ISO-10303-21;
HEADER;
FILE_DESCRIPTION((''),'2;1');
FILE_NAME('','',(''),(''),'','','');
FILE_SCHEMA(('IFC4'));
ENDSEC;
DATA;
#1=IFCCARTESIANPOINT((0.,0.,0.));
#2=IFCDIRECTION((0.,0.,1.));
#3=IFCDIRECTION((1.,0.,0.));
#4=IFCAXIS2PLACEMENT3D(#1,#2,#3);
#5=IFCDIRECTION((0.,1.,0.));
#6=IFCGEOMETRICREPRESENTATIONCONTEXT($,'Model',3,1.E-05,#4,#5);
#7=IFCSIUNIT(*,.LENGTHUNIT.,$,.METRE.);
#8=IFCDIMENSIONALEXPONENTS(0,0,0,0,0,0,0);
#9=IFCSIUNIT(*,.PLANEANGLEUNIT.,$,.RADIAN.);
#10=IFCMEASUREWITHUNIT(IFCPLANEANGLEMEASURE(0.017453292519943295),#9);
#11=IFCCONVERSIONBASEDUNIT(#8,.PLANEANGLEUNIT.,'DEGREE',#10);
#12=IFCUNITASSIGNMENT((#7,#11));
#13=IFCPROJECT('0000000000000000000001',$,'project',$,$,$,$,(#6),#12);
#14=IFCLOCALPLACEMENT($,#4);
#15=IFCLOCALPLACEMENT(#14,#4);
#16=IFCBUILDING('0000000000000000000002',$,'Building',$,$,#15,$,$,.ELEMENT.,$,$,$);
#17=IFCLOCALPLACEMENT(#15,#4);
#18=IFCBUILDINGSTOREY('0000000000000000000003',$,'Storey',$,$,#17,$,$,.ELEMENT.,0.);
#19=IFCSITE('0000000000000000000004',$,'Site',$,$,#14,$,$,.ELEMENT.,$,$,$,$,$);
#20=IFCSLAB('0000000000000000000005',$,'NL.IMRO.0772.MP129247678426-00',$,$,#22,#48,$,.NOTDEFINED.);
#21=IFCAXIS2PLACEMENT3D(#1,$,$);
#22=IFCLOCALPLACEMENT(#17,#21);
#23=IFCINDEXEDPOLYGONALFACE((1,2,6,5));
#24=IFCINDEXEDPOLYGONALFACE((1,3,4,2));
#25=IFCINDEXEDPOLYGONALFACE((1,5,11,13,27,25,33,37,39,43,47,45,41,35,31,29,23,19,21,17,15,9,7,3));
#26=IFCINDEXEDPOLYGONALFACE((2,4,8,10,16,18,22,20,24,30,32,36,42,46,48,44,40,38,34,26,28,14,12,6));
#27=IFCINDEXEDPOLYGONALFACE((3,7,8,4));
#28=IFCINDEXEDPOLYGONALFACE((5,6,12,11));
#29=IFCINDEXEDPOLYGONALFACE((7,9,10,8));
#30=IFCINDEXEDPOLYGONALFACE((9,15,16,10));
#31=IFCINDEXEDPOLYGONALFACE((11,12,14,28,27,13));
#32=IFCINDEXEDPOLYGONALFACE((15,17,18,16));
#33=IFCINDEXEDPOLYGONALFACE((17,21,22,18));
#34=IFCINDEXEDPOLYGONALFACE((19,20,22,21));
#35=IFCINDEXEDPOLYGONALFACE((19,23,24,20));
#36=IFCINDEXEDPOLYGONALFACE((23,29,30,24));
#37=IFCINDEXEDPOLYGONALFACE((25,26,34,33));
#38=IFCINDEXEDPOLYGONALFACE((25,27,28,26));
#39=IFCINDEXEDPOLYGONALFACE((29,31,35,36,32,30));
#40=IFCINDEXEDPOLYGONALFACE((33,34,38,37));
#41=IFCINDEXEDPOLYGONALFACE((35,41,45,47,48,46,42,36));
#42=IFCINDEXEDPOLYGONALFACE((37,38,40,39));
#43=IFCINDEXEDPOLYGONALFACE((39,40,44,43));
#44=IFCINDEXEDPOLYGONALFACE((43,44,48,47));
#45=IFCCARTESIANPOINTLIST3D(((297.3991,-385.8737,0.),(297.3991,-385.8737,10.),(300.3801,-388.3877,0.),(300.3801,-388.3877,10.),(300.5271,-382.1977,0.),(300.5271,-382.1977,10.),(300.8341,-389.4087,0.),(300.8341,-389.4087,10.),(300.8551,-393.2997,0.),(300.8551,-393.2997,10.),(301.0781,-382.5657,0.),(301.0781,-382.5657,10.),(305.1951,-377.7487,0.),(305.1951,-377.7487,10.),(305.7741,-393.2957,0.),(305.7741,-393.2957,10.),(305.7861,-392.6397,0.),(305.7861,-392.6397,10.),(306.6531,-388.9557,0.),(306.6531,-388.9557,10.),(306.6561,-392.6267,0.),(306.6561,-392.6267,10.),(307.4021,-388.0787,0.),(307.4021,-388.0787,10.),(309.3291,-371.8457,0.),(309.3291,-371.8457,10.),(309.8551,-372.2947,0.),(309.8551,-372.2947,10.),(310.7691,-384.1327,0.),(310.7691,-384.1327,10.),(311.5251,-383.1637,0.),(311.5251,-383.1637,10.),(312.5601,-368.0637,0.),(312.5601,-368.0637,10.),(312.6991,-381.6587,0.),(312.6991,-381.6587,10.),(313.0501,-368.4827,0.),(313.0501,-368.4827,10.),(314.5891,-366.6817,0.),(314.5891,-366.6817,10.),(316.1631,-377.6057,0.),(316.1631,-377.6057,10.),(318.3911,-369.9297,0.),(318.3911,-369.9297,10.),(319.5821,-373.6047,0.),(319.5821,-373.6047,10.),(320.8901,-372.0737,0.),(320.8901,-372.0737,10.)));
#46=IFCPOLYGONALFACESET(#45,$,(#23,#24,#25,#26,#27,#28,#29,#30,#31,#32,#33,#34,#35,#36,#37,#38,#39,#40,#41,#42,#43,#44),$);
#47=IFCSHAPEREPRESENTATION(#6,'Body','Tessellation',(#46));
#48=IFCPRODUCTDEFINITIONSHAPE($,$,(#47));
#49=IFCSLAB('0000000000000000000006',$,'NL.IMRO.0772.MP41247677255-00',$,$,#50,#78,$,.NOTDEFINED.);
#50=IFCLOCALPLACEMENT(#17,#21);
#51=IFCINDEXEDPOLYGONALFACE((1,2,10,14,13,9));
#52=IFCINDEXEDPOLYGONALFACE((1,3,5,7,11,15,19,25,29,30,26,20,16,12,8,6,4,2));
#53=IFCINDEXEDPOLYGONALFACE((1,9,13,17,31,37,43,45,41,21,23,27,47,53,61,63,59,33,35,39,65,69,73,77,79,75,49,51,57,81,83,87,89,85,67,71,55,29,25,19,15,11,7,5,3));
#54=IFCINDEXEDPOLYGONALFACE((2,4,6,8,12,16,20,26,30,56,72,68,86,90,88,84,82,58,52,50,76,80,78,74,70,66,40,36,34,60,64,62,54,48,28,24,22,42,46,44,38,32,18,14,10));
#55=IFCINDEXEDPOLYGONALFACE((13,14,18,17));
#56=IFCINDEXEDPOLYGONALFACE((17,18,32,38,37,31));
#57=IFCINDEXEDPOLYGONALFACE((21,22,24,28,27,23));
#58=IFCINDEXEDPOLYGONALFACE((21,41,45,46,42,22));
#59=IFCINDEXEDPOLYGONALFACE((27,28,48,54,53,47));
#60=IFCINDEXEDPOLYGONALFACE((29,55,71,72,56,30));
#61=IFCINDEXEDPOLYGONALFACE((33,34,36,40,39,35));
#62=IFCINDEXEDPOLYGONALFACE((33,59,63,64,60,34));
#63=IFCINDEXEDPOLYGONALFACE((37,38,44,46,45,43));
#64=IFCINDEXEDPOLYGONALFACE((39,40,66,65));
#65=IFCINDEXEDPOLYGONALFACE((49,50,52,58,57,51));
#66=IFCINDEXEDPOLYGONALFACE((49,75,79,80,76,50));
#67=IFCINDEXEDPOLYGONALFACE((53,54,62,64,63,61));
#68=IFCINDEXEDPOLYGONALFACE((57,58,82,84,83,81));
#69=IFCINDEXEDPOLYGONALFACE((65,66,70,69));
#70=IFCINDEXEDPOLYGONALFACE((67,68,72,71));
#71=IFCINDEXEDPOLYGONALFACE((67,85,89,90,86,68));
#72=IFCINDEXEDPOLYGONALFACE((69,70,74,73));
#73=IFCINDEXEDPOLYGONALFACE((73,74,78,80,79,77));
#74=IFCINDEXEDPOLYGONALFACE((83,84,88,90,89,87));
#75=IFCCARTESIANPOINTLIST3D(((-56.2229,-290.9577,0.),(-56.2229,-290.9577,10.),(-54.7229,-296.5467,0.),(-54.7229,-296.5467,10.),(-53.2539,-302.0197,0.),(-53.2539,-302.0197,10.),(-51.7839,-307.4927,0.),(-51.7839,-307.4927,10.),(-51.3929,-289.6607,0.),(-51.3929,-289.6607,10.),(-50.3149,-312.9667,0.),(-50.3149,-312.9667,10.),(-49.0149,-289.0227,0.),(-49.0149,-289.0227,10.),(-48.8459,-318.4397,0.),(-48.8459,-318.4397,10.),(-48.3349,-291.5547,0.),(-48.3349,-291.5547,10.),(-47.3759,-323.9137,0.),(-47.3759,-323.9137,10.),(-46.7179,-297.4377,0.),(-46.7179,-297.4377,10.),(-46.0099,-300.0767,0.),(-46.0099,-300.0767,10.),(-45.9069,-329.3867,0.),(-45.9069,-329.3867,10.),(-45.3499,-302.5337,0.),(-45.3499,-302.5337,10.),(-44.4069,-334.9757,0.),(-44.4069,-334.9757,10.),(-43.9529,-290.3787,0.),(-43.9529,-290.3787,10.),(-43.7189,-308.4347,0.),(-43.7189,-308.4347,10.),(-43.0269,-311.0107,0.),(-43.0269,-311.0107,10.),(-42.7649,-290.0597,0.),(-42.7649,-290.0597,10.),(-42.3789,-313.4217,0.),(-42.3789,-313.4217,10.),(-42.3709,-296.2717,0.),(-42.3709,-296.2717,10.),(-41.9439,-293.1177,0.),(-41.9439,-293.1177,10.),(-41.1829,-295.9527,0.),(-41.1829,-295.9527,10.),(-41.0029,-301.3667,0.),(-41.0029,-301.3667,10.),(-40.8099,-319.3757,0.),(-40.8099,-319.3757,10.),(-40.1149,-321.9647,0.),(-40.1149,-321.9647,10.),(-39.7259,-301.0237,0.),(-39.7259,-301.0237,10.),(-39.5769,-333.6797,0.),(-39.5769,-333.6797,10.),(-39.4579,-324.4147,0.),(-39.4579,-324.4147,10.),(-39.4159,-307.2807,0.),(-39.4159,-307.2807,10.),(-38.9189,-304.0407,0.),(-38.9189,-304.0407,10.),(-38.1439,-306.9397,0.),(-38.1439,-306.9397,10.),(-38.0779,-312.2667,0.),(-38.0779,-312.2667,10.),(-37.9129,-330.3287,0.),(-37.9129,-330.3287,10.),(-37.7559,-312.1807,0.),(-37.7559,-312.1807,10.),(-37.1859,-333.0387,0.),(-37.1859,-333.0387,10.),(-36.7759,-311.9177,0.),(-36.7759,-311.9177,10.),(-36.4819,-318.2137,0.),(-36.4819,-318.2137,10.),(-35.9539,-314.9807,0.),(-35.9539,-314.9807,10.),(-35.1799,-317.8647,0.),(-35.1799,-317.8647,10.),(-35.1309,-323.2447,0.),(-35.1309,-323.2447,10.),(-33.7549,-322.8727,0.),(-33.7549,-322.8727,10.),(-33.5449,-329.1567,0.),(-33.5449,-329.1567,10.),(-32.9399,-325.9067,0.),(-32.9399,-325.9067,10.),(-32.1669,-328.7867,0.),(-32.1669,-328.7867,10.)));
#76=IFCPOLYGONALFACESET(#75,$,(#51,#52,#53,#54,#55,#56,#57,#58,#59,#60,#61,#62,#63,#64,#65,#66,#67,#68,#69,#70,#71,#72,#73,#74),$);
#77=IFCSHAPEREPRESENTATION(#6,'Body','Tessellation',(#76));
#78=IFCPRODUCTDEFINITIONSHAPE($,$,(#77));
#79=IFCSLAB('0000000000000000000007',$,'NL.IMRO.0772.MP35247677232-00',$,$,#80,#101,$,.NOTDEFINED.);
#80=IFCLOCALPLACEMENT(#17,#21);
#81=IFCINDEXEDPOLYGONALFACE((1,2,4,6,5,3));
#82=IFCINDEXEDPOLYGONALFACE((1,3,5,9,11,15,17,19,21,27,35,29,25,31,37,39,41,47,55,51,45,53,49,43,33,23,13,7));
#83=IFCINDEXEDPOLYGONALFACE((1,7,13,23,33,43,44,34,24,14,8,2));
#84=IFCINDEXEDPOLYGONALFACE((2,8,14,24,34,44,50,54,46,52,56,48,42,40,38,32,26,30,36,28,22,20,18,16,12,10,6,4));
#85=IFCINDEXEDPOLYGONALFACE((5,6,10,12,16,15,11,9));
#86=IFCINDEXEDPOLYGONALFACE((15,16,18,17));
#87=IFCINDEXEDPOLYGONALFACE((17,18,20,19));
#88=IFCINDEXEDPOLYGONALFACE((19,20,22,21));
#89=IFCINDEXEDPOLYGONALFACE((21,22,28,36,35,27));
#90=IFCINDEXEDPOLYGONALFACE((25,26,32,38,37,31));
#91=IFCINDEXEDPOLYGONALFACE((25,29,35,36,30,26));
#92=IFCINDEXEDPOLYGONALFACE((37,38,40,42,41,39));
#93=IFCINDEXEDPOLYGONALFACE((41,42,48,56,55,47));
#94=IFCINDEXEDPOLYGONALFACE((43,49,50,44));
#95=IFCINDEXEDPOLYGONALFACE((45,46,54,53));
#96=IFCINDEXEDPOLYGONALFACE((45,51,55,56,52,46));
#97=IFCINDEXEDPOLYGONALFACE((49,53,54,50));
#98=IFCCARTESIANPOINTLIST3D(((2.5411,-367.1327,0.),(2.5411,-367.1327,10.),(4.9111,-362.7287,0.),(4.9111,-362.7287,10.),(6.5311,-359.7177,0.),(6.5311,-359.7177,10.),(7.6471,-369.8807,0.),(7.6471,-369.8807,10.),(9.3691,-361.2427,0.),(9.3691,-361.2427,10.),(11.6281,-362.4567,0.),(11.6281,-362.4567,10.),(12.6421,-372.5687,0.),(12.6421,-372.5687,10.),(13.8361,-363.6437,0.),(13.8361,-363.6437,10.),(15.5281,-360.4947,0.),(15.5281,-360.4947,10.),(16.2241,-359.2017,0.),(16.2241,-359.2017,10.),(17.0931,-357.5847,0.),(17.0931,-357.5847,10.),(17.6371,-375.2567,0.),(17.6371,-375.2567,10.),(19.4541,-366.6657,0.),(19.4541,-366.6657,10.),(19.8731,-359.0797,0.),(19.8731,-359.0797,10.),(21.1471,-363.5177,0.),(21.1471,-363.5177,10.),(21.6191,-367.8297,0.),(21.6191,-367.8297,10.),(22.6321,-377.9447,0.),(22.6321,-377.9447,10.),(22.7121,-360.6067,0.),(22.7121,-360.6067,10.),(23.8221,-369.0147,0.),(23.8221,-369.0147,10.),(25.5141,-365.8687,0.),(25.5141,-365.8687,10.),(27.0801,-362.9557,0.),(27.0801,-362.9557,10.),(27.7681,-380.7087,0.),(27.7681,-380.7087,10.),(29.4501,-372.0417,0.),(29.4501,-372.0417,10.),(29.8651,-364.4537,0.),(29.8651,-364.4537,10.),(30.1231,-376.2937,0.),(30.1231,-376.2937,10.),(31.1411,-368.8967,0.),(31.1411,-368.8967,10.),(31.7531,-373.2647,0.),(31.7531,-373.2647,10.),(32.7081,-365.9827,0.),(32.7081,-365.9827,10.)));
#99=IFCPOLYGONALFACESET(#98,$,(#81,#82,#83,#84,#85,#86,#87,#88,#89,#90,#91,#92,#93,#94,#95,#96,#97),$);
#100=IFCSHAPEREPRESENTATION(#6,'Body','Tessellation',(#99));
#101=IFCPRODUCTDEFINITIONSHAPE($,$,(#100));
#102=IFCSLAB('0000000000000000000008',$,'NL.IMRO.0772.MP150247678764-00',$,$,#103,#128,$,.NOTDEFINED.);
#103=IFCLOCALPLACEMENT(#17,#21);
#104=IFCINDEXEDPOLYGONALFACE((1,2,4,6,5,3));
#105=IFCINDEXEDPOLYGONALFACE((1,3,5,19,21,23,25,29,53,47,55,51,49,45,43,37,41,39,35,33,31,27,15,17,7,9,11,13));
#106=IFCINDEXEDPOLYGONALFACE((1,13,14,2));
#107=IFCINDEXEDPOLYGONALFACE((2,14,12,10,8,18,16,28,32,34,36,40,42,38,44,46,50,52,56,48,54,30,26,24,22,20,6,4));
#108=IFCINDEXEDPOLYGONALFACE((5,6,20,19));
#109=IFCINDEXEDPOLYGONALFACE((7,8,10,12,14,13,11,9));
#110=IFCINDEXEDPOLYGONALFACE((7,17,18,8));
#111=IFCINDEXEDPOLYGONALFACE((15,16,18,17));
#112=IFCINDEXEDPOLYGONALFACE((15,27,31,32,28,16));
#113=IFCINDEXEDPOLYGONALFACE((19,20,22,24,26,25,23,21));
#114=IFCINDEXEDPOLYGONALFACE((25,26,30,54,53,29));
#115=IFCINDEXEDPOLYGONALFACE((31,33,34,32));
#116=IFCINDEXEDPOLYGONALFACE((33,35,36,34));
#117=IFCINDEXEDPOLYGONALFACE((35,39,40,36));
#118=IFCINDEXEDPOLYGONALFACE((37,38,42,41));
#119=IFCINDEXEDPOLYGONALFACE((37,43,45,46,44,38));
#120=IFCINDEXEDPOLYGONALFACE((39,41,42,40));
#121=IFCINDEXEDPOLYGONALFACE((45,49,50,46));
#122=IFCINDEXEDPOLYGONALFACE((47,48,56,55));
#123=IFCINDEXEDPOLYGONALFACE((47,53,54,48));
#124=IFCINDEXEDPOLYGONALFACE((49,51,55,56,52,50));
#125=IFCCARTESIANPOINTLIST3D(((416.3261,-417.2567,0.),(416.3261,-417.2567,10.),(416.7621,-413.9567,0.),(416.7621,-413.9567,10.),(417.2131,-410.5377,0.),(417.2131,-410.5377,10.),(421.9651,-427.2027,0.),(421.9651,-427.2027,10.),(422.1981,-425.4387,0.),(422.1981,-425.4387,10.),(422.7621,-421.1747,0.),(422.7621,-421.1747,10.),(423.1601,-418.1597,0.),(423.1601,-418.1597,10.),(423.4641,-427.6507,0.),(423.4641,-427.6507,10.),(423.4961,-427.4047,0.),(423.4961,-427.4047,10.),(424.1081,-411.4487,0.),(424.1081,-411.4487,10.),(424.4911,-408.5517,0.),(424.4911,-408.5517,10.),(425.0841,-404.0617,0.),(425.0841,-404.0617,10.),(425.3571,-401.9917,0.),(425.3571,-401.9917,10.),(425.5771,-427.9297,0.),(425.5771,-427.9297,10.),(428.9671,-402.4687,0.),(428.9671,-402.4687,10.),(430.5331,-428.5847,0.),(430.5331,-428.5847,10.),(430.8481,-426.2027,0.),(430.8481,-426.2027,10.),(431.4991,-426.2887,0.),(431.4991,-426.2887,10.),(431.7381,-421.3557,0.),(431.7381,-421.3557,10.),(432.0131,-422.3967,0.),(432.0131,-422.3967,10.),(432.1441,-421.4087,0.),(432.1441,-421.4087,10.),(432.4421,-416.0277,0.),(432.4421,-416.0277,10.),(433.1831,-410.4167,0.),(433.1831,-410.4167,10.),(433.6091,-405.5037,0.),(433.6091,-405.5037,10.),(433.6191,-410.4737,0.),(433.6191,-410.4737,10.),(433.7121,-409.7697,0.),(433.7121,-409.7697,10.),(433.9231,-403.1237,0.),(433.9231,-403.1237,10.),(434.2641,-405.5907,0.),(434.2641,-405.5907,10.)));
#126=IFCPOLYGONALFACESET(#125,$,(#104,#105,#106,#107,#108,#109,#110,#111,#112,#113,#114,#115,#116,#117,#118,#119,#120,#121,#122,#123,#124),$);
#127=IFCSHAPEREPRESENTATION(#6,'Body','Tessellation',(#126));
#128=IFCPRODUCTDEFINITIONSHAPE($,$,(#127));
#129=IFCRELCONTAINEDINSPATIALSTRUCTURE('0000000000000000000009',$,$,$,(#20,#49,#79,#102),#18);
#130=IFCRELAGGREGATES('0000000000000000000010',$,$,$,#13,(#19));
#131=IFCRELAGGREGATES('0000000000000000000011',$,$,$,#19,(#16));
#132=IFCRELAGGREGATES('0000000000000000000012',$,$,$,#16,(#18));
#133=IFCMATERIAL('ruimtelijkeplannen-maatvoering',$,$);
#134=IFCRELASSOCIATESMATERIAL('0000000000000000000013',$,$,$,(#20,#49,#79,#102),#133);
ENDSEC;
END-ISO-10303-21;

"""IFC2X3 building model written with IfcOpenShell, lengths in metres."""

from ifc_helpers import new_model, entity, si_unit, converted_unit, direction, origin_with_axes, place, context, project, spatial, polyline, outline, extrude, material, element, save


model = new_model("IFC2X3")

# Units and contexts
model_context = context("Model", 3, precision=1e-05, world=origin_with_axes(), true_north=direction((0.0, 1.0, 0.0)))
ifc_project = project(units=[si_unit("LENGTHUNIT", "METRE"), converted_unit("PLANEANGLEUNIT", "DEGREE", entity("IfcPlaneAngleMeasure", 0.017453292519943295), si_unit("PLANEANGLEUNIT", "RADIAN"), dimensions=[0, 0, 0, 0, 0, 0, 0])], contexts=[model_context])

# Site, building, storey
site_placement = place(None, origin_with_axes())
site = spatial("IfcSite", under=ifc_project, at=site_placement, Name="Site", CompositionType="ELEMENT")
building_placement = place(site_placement, origin_with_axes())
building = spatial("IfcBuilding", under=site, at=building_placement, Name="Building", CompositionType="ELEMENT")
storey_placement = place(building_placement, origin_with_axes())
storey = spatial("IfcBuildingStorey", under=building, at=storey_placement, Name="Storey", CompositionType="ELEMENT", Elevation=0.0)

# Slabs
ifc_material = material(Name="ruimtelijkeplannen-maatvoering")
slab_1_placement = place(storey_placement, origin_with_axes())
element("IfcSlab", 1, at=slab_1_placement, inside=storey, material=ifc_material, Name="NL.IMRO.0772.MP129247678426-00", PredefinedType="NOTDEFINED", context=model_context, shape_type="SweptSolid", body=[
    extrude(outline(polyline([(300.3801, -388.3877), (297.3991, -385.8737), (300.5271, -382.1977), (301.0781, -382.5657), (305.1951, -377.7487), (309.8551, -372.2947), (309.3291, -371.8457), (312.5601, -368.0637), (313.0501, -368.4827), (314.5891, -366.6817), (318.3911, -369.9297), (320.8901, -372.0737), (319.5821, -373.6047), (316.1631, -377.6057), (312.6991, -381.6587), (311.5251, -383.1637), (310.7691, -384.1327), (307.4021, -388.0787), (306.6531, -388.9557), (306.6561, -392.6267), (305.7861, -392.6397), (305.7741, -393.2957), (300.8551, -393.2997), (300.8341, -389.4087), (300.3801, -388.3877)])), origin_with_axes(), (0.0, 0.0, 1.0), 10.0),
])
slab_2_placement = place(storey_placement, origin_with_axes())
element("IfcSlab", 2, at=slab_2_placement, inside=storey, material=ifc_material, Name="NL.IMRO.0772.MP41247677255-00", PredefinedType="NOTDEFINED", context=model_context, shape_type="SweptSolid", body=[
    extrude(outline(polyline([(-56.2229, -290.9577), (-51.3929, -289.6607), (-49.0149, -289.0227), (-48.3349, -291.5547), (-43.9529, -290.3787), (-42.7649, -290.0597), (-41.9439, -293.1177), (-41.1829, -295.9527), (-42.3709, -296.2717), (-46.7179, -297.4377), (-46.0099, -300.0767), (-45.3499, -302.5337), (-41.0029, -301.3667), (-39.7259, -301.0237), (-38.9189, -304.0407), (-38.1439, -306.9397), (-39.4159, -307.2807), (-43.7189, -308.4347), (-43.0269, -311.0107), (-42.3789, -313.4217), (-38.0779, -312.2667), (-37.7559, -312.1807), (-36.7759, -311.9177), (-35.9539, -314.9807), (-35.1799, -317.8647), (-36.4819, -318.2137), (-40.8099, -319.3757), (-40.1149, -321.9647), (-39.4579, -324.4147), (-35.1309, -323.2447), (-33.7549, -322.8727), (-32.9399, -325.9067), (-32.1669, -328.7867), (-33.5449, -329.1567), (-37.9129, -330.3287), (-37.1859, -333.0387), (-39.5769, -333.6797), (-44.4069, -334.9757), (-45.9069, -329.3867), (-47.3759, -323.9137), (-48.8459, -318.4397), (-50.3149, -312.9667), (-51.7839, -307.4927), (-53.2539, -302.0197), (-54.7229, -296.5467), (-56.2229, -290.9577)])), origin_with_axes(), (0.0, 0.0, 1.0), 10.0),
])
slab_3_placement = place(storey_placement, origin_with_axes())
element("IfcSlab", 3, at=slab_3_placement, inside=storey, material=ifc_material, Name="NL.IMRO.0772.MP35247677232-00", PredefinedType="NOTDEFINED", context=model_context, shape_type="SweptSolid", body=[
    extrude(outline(polyline([(7.6471, -369.8807), (2.5411, -367.1327), (4.9111, -362.7287), (6.5311, -359.7177), (9.3691, -361.2427), (11.6281, -362.4567), (13.8361, -363.6437), (15.5281, -360.4947), (16.2241, -359.2017), (17.0931, -357.5847), (19.8731, -359.0797), (22.7121, -360.6067), (21.1471, -363.5177), (19.4541, -366.6657), (21.6191, -367.8297), (23.8221, -369.0147), (25.5141, -365.8687), (27.0801, -362.9557), (29.8651, -364.4537), (32.7081, -365.9827), (31.1411, -368.8967), (29.4501, -372.0417), (31.7531, -373.2647), (30.1231, -376.2937), (27.7681, -380.7087), (22.6321, -377.9447), (17.6371, -375.2567), (12.6421, -372.5687), (7.6471, -369.8807)])), origin_with_axes(), (0.0, 0.0, 1.0), 10.0),
])
slab_4_placement = place(storey_placement, origin_with_axes())
element("IfcSlab", 4, at=slab_4_placement, inside=storey, material=ifc_material, Name="NL.IMRO.0772.MP150247678764-00", PredefinedType="NOTDEFINED", context=model_context, shape_type="SweptSolid", body=[
    extrude(outline(polyline([(421.9651, -427.2027), (422.1981, -425.4387), (422.7621, -421.1747), (423.1601, -418.1597), (416.3261, -417.2567), (416.7621, -413.9567), (417.2131, -410.5377), (424.1081, -411.4487), (424.4911, -408.5517), (425.0841, -404.0617), (425.3571, -401.9917), (428.9671, -402.4687), (433.9231, -403.1237), (433.6091, -405.5037), (434.2641, -405.5907), (433.7121, -409.7697), (433.6191, -410.4737), (433.1831, -410.4167), (432.4421, -416.0277), (431.7381, -421.3557), (432.1441, -421.4087), (432.0131, -422.3967), (431.4991, -426.2887), (430.8481, -426.2027), (430.5331, -428.5847), (425.5771, -427.9297), (423.4641, -427.6507), (423.4961, -427.4047), (421.9651, -427.2027)])), origin_with_axes(), (0.0, 0.0, 1.0), 10.0),
])

save(model, "model.ifc")
